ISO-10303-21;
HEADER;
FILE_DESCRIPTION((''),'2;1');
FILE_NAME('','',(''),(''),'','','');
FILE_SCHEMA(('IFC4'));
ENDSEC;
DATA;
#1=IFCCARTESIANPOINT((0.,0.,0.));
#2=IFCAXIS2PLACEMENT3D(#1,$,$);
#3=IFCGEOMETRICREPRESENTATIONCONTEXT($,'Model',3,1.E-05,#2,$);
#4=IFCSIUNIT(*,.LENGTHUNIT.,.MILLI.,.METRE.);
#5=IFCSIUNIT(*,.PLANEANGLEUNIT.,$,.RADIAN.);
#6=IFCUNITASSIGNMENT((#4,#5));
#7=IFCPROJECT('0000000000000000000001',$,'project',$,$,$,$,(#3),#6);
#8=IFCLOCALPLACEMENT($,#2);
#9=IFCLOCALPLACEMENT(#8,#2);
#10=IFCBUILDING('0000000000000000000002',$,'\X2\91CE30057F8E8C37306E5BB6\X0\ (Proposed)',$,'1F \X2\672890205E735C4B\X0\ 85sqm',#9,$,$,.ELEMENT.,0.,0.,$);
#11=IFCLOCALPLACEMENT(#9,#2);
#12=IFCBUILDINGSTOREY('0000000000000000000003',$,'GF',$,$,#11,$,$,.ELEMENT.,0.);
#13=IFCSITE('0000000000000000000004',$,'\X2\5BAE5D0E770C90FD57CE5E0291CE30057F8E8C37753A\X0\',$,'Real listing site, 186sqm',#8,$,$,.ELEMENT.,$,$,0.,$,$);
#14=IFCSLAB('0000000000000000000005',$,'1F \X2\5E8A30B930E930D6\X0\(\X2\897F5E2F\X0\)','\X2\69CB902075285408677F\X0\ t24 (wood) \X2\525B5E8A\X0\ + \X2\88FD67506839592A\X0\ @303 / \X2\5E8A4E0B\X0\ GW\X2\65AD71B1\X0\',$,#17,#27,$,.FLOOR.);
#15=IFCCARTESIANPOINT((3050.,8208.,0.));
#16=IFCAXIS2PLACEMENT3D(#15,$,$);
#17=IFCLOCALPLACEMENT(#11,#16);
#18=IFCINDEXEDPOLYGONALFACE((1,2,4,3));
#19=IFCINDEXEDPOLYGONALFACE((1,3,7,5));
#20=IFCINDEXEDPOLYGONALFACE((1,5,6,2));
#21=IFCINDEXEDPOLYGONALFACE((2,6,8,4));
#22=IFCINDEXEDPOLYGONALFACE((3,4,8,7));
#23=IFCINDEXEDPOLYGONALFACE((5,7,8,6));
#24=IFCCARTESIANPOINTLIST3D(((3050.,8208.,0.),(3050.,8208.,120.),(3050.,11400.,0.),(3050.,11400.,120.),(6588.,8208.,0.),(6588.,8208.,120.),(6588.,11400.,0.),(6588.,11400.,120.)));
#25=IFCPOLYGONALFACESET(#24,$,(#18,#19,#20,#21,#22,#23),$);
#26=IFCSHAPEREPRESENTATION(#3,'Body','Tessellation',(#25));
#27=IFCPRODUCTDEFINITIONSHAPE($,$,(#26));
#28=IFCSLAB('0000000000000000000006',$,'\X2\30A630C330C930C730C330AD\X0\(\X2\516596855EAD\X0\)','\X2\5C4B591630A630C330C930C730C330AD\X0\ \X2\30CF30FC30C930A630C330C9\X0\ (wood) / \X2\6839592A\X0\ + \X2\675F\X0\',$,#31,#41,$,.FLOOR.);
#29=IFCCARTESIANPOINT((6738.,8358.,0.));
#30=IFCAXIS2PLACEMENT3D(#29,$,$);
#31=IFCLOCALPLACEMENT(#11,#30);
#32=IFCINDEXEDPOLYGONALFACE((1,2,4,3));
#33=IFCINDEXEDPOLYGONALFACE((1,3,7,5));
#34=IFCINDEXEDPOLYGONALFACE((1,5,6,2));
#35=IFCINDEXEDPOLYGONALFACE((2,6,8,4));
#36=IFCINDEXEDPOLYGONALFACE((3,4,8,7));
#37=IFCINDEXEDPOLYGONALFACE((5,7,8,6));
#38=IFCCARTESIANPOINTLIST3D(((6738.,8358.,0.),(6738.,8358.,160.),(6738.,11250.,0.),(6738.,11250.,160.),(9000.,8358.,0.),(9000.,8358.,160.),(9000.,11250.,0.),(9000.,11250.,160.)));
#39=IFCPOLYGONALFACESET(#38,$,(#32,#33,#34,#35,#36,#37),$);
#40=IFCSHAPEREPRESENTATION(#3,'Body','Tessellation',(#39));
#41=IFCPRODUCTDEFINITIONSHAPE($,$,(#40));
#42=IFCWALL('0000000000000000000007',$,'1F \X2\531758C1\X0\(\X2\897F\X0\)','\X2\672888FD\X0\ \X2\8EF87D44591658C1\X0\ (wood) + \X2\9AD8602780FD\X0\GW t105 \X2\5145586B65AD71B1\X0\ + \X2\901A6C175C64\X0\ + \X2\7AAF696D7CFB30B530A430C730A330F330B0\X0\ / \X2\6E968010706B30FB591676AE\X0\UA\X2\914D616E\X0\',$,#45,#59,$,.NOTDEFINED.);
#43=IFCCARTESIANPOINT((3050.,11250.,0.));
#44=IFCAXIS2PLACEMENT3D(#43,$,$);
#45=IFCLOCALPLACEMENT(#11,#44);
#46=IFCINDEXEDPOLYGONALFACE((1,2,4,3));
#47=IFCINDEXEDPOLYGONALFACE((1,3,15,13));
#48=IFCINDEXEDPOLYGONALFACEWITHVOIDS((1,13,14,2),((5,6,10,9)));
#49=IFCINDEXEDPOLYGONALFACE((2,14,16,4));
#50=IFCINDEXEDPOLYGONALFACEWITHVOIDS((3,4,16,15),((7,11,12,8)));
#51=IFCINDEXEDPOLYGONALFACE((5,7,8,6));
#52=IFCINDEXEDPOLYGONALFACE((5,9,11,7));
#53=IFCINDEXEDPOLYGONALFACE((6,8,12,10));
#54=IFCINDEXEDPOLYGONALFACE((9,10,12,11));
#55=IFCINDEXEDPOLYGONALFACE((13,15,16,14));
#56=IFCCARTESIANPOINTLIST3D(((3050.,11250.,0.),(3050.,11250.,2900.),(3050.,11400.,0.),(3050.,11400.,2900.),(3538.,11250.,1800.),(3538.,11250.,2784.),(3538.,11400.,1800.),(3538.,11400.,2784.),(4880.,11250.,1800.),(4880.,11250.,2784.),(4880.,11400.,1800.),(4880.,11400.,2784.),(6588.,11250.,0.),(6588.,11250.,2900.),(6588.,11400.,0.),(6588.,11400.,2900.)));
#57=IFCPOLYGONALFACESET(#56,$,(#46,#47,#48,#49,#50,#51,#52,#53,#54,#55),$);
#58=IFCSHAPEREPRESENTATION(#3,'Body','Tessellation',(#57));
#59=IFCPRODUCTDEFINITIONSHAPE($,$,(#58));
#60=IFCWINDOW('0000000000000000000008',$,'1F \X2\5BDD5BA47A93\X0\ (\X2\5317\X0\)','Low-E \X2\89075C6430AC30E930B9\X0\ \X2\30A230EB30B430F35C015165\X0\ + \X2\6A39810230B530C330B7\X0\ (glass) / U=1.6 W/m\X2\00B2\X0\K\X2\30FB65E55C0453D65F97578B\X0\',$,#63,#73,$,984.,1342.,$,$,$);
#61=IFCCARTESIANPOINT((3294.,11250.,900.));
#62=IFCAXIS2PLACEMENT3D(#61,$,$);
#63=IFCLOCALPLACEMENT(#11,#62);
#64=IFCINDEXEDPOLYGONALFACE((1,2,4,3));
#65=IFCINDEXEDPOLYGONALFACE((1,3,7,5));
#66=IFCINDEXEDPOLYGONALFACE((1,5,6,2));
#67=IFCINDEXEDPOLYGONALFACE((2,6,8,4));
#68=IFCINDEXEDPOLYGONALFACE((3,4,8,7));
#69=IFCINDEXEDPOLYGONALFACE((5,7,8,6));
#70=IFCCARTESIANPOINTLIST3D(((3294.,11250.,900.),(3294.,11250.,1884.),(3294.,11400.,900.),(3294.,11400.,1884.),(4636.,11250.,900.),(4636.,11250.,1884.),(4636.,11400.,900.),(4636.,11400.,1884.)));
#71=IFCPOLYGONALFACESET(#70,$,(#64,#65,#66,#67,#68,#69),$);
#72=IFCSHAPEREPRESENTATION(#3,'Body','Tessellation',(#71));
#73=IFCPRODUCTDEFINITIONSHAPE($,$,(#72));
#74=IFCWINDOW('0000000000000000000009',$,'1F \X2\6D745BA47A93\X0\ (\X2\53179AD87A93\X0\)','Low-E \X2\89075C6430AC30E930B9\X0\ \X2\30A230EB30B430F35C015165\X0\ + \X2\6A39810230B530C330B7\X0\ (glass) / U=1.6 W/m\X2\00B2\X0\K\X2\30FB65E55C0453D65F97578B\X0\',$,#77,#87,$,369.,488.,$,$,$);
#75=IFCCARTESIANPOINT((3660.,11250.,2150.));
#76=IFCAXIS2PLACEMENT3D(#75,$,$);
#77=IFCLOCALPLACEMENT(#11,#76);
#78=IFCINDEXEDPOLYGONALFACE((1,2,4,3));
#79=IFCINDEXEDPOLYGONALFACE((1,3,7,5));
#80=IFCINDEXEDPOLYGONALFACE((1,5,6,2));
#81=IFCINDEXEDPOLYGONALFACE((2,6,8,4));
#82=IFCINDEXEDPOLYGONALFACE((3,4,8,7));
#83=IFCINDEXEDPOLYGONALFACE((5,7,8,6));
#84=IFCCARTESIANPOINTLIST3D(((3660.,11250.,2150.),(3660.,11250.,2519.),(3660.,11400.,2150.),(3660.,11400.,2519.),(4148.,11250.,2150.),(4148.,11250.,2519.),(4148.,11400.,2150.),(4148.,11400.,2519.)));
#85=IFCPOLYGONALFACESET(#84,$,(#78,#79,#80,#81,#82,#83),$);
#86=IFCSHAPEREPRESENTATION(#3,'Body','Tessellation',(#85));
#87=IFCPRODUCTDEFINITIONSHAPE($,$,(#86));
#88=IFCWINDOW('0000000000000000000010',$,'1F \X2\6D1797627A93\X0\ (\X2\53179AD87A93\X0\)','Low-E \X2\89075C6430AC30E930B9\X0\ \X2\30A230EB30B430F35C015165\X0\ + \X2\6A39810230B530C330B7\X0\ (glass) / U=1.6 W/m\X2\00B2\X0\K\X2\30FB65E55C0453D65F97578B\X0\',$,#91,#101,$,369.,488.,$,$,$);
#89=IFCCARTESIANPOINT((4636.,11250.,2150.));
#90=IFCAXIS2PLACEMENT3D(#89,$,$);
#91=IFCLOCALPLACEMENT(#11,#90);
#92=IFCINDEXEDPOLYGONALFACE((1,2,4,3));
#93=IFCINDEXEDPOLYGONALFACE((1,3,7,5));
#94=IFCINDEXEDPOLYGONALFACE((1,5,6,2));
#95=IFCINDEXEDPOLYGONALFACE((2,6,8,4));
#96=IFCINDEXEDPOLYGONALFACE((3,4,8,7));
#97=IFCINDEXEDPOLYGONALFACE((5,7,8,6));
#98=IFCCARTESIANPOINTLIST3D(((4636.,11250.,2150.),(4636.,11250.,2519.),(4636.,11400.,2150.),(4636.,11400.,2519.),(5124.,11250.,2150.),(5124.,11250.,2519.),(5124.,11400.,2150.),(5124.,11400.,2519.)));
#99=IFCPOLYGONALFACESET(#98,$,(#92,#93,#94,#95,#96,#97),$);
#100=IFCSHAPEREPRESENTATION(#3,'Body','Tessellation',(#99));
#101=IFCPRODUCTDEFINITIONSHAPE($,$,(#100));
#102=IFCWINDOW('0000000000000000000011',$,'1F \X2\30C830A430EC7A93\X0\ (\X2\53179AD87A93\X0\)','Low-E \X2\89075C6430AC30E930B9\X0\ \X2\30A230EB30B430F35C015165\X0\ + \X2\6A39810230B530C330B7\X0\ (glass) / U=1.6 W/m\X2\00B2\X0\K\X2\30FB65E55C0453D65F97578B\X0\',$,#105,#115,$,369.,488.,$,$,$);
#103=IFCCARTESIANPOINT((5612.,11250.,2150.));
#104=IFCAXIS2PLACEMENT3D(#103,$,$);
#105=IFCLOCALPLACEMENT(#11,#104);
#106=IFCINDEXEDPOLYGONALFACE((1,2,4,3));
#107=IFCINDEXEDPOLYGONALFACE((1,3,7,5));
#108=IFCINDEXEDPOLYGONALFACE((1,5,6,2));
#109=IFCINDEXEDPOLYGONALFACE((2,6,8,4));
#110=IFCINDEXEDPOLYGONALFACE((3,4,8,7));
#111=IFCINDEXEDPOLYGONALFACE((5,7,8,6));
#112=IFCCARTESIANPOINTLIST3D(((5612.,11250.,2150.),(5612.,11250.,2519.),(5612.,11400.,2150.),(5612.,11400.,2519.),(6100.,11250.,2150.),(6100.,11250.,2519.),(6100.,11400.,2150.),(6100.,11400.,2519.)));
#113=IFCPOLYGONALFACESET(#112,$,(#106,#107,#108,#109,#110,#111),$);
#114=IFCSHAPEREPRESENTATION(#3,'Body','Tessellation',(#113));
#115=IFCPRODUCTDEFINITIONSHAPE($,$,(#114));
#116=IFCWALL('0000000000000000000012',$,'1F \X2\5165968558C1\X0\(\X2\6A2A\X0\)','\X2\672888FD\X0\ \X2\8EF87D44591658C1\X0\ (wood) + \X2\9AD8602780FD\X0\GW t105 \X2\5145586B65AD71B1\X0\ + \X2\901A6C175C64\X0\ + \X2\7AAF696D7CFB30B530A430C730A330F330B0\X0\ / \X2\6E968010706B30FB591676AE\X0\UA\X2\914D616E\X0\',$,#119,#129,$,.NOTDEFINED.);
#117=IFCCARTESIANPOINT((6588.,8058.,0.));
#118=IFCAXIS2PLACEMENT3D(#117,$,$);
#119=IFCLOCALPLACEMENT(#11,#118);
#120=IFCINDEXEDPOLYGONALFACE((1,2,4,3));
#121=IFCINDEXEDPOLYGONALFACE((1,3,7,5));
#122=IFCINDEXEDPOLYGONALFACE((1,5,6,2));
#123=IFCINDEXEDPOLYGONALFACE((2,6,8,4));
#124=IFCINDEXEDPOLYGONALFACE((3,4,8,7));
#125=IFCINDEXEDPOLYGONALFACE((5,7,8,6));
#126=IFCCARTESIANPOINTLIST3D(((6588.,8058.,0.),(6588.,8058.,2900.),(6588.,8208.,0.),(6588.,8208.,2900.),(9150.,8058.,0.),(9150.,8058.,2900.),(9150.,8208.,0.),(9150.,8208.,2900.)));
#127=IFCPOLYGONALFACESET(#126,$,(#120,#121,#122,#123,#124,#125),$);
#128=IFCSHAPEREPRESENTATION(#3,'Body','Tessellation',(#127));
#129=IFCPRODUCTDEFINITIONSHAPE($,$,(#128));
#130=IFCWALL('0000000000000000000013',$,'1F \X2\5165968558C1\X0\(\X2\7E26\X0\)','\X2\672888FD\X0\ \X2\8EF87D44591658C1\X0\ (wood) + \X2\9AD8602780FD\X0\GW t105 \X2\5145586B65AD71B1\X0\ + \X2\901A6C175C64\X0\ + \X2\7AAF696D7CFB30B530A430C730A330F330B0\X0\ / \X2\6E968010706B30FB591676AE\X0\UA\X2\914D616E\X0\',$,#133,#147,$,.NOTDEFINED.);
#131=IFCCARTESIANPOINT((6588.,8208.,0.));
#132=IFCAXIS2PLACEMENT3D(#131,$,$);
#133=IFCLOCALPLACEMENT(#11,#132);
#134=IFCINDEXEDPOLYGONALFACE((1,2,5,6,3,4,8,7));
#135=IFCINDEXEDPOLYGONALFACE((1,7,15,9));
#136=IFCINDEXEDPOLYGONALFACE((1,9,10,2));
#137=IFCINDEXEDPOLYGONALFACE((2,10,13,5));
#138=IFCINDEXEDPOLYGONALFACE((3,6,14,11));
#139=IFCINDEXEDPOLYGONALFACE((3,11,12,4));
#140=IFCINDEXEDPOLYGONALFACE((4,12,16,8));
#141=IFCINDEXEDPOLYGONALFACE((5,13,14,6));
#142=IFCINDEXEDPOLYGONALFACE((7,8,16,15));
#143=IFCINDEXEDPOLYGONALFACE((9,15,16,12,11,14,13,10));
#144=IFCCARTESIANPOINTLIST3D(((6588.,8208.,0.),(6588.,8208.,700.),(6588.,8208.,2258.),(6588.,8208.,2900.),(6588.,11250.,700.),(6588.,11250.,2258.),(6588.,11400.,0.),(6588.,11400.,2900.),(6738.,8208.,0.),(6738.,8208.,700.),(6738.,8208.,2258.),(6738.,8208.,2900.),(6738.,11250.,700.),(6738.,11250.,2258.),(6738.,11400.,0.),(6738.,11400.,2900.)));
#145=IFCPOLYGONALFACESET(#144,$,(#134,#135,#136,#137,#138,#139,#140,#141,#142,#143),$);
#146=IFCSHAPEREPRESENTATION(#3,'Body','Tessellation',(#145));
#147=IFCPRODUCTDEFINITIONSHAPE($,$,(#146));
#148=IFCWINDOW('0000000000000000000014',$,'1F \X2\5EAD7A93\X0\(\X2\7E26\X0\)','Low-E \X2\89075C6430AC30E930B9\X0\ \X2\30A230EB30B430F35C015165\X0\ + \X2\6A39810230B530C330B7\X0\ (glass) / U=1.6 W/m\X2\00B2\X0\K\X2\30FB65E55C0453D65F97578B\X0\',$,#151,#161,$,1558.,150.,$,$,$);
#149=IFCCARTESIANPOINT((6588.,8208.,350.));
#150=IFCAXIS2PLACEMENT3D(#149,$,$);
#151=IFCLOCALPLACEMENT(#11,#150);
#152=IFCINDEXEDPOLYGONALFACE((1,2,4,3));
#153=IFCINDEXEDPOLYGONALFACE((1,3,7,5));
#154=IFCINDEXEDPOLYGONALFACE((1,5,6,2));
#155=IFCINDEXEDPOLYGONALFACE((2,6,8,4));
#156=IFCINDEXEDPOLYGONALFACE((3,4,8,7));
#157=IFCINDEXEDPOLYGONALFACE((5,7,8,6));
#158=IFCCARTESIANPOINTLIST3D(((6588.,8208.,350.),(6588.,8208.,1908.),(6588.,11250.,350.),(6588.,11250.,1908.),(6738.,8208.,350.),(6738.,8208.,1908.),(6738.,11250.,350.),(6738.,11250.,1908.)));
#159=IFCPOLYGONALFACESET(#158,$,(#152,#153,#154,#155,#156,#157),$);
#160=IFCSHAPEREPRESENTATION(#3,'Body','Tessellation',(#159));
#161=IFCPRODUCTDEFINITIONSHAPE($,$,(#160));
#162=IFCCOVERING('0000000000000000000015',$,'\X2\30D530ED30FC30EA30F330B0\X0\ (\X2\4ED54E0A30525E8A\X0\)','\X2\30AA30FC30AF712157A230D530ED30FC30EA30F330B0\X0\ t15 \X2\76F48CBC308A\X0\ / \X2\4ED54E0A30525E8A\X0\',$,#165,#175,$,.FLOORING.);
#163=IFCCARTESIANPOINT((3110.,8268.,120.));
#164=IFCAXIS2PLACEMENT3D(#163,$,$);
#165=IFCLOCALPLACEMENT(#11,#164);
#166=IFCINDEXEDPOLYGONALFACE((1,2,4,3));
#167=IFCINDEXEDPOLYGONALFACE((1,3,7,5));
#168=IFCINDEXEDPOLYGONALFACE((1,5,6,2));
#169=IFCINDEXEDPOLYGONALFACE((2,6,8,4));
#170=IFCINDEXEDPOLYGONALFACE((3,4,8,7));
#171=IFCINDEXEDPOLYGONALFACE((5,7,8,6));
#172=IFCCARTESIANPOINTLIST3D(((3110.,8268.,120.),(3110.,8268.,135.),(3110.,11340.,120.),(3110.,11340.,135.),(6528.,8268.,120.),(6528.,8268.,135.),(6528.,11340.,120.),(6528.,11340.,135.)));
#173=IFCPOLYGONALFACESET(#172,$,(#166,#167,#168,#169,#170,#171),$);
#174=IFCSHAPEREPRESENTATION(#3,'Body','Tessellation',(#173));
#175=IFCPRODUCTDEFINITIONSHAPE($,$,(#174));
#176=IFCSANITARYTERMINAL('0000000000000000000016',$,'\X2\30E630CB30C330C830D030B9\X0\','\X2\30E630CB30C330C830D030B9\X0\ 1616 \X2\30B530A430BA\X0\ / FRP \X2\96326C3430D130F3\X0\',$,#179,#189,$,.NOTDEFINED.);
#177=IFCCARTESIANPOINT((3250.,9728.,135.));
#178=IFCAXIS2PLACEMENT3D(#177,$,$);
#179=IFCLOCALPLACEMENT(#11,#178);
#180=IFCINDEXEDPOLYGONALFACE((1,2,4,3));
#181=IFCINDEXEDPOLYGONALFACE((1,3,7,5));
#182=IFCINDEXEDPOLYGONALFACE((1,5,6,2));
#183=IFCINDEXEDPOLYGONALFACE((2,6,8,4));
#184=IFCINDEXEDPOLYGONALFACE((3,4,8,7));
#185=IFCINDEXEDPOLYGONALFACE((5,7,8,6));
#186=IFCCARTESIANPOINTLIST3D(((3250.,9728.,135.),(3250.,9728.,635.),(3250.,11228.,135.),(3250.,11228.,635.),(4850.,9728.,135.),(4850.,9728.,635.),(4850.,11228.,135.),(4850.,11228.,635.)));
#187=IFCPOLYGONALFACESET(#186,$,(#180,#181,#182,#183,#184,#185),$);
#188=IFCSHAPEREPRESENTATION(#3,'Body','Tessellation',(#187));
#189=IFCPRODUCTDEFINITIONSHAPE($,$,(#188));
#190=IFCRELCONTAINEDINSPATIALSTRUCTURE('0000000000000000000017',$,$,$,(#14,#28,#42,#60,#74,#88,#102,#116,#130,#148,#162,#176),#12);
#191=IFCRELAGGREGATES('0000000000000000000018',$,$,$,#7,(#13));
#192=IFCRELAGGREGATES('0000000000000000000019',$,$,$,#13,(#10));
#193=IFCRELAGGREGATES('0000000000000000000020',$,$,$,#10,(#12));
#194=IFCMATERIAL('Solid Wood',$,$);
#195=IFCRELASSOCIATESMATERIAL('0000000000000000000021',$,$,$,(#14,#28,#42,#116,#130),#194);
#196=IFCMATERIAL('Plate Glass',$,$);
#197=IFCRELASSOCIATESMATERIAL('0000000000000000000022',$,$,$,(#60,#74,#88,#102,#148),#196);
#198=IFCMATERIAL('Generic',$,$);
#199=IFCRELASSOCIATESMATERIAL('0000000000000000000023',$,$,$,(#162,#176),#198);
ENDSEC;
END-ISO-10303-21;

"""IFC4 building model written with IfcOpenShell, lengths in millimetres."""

from ifc_helpers import new_model, si_unit, frame, frame_2d, origin, place, context, project, spatial, rectangle, extrude, material, element, fill, save


model = new_model("IFC4")

# Units and contexts
model_context = context("Model", 3, precision=1e-05, world=origin())
ifc_project = project(units=[si_unit("LENGTHUNIT", "METRE", prefix="MILLI"), si_unit("PLANEANGLEUNIT", "RADIAN")], contexts=[model_context])

# Site, building, storey
site_placement = place(None, origin())
site = spatial("IfcSite", under=ifc_project, at=site_placement, Name="宮崎県都城市野々美谷町", ObjectType="Real listing site, 186sqm", CompositionType="ELEMENT", RefElevation=0.0)
building_placement = place(site_placement, origin())
building = spatial("IfcBuilding", under=site, at=building_placement, Name="野々美谷の家 (Proposed)", ObjectType="1F 木造平屋 85sqm", CompositionType="ELEMENT", ElevationOfRefHeight=0.0, ElevationOfTerrain=0.0)
storey_placement = place(building_placement, origin())
storey = spatial("IfcBuildingStorey", under=building, at=storey_placement, Name="GF", CompositionType="ELEMENT", Elevation=0.0)

# Slabs
ifc_material_1 = material(Name="Solid Wood")
slab_1_placement = place(storey_placement, frame((3050.0, 8208.0, 0.0)))
element("IfcSlab", 1, at=slab_1_placement, inside=storey, material=ifc_material_1, Name="1F 床スラブ(西帯)", Description="構造用合板 t24 (wood) 剛床 + 製材根太 @303 / 床下 GW断熱", PredefinedType="FLOOR", context=model_context, shape_type="SweptSolid", body=[
    extrude(rectangle(XDim=3538.0, YDim=3192.0, at=frame_2d((1769.0, 1596.0))), frame((3050.0, 8208.0, 0.0)), (0.0, 0.0, 1.0), 120.0),
])
slab_2_placement = place(storey_placement, frame((6738.0, 8358.0, 0.0)))
element("IfcSlab", 2, at=slab_2_placement, inside=storey, material=ifc_material_1, Name="ウッドデッキ(入隅庭)", Description="屋外ウッドデッキ ハードウッド (wood) / 根太 + 束", PredefinedType="FLOOR", context=model_context, shape_type="SweptSolid", body=[
    extrude(rectangle(XDim=2262.0, YDim=2892.0, at=frame_2d((1131.0, 1446.0))), frame((6738.0, 8358.0, 0.0)), (0.0, 0.0, 1.0), 160.0),
])

# Wall, openings, windows
wall_1_placement = place(storey_placement, frame((3050.0, 11250.0, 0.0)))
wall_1 = element("IfcWall", 3, at=wall_1_placement, inside=storey, material=ifc_material_1, Name="1F 北壁(西)", Description="木製 軸組外壁 (wood) + 高性能GW t105 充填断熱 + 通気層 + 窯業系サイディング / 準耐火・外皮UA配慮", PredefinedType="NOTDEFINED", context=model_context, shape_type="SweptSolid", body=[
    extrude(rectangle(XDim=3538.0, YDim=150.0, at=frame_2d((1769.0, 75.0))), frame((3050.0, 11250.0, 0.0)), (0.0, 0.0, 1.0), 2900.0),
])
opening_1_placement = place(storey_placement, frame((3294.0, 11250.0, 900.0)))
opening_1 = element("IfcOpeningElement", 4, at=opening_1_placement, cuts=wall_1, PredefinedType="NOTDEFINED", context=model_context, shape_type="SweptSolid", body=[
    extrude(rectangle(XDim=1342.0, YDim=150.0, at=frame_2d((671.0, 75.0))), frame((3294.0, 11250.0, 900.0)), (0.0, 0.0, 1.0), 984.0),
])
opening_2_placement = place(storey_placement, frame((3660.0, 11250.0, 2150.0)))
opening_2 = element("IfcOpeningElement", 5, at=opening_2_placement, cuts=wall_1, PredefinedType="NOTDEFINED", context=model_context, shape_type="SweptSolid", body=[
    extrude(rectangle(XDim=488.0, YDim=150.0, at=frame_2d((244.0, 75.0))), frame((3660.0, 11250.0, 2150.0)), (0.0, 0.0, 1.0), 369.0),
])
opening_3_placement = place(storey_placement, frame((4636.0, 11250.0, 2150.0)))
opening_3 = element("IfcOpeningElement", 6, at=opening_3_placement, cuts=wall_1, PredefinedType="NOTDEFINED", context=model_context, shape_type="SweptSolid", body=[
    extrude(rectangle(XDim=488.0, YDim=150.0, at=frame_2d((244.0, 75.0))), frame((4636.0, 11250.0, 2150.0)), (0.0, 0.0, 1.0), 369.0),
])
opening_4_placement = place(storey_placement, frame((5612.0, 11250.0, 2150.0)))
opening_4 = element("IfcOpeningElement", 7, at=opening_4_placement, cuts=wall_1, PredefinedType="NOTDEFINED", context=model_context, shape_type="SweptSolid", body=[
    extrude(rectangle(XDim=488.0, YDim=150.0, at=frame_2d((244.0, 75.0))), frame((5612.0, 11250.0, 2150.0)), (0.0, 0.0, 1.0), 369.0),
])
ifc_material_2 = material(Name="Plate Glass")
window_1_placement = place(storey_placement, frame((3294.0, 11250.0, 900.0)))
window_1 = element("IfcWindow", 8, at=window_1_placement, inside=storey, material=ifc_material_2, Name="1F 寝室窓 (北)", Description="Low-E 複層ガラス アルゴン封入 + 樹脂サッシ (glass) / U=1.6 W/m²K・日射取得型", OverallHeight=984.0, OverallWidth=1342.0, context=model_context, shape_type="SweptSolid", body=[
    extrude(rectangle(XDim=1342.0, YDim=150.0, at=frame_2d((671.0, 75.0))), frame((3294.0, 11250.0, 900.0)), (0.0, 0.0, 1.0), 984.0),
])
fill(opening_1, window_1)
window_2_placement = place(storey_placement, frame((3660.0, 11250.0, 2150.0)))
window_2 = element("IfcWindow", 9, at=window_2_placement, inside=storey, material=ifc_material_2, Name="1F 浴室窓 (北高窓)", Description="Low-E 複層ガラス アルゴン封入 + 樹脂サッシ (glass) / U=1.6 W/m²K・日射取得型", OverallHeight=369.0, OverallWidth=488.0, context=model_context, shape_type="SweptSolid", body=[
    extrude(rectangle(XDim=488.0, YDim=150.0, at=frame_2d((244.0, 75.0))), frame((3660.0, 11250.0, 2150.0)), (0.0, 0.0, 1.0), 369.0),
])
fill(opening_2, window_2)
window_3_placement = place(storey_placement, frame((4636.0, 11250.0, 2150.0)))
window_3 = element("IfcWindow", 10, at=window_3_placement, inside=storey, material=ifc_material_2, Name="1F 洗面窓 (北高窓)", Description="Low-E 複層ガラス アルゴン封入 + 樹脂サッシ (glass) / U=1.6 W/m²K・日射取得型", OverallHeight=369.0, OverallWidth=488.0, context=model_context, shape_type="SweptSolid", body=[
    extrude(rectangle(XDim=488.0, YDim=150.0, at=frame_2d((244.0, 75.0))), frame((4636.0, 11250.0, 2150.0)), (0.0, 0.0, 1.0), 369.0),
])
fill(opening_3, window_3)
window_4_placement = place(storey_placement, frame((5612.0, 11250.0, 2150.0)))
window_4 = element("IfcWindow", 11, at=window_4_placement, inside=storey, material=ifc_material_2, Name="1F トイレ窓 (北高窓)", Description="Low-E 複層ガラス アルゴン封入 + 樹脂サッシ (glass) / U=1.6 W/m²K・日射取得型", OverallHeight=369.0, OverallWidth=488.0, context=model_context, shape_type="SweptSolid", body=[
    extrude(rectangle(XDim=488.0, YDim=150.0, at=frame_2d((244.0, 75.0))), frame((5612.0, 11250.0, 2150.0)), (0.0, 0.0, 1.0), 369.0),
])
fill(opening_4, window_4)

# Wall
wall_2_placement = place(storey_placement, frame((6588.0, 8058.0, 0.0)))
element("IfcWall", 12, at=wall_2_placement, inside=storey, material=ifc_material_1, Name="1F 入隅壁(横)", Description="木製 軸組外壁 (wood) + 高性能GW t105 充填断熱 + 通気層 + 窯業系サイディング / 準耐火・外皮UA配慮", PredefinedType="NOTDEFINED", context=model_context, shape_type="SweptSolid", body=[
    extrude(rectangle(XDim=2562.0, YDim=150.0, at=frame_2d((1281.0, 75.0))), frame((6588.0, 8058.0, 0.0)), (0.0, 0.0, 1.0), 2900.0),
])

# Wall, opening, window
wall_3_placement = place(storey_placement, frame((6588.0, 8208.0, 0.0)))
wall_3 = element("IfcWall", 13, at=wall_3_placement, inside=storey, material=ifc_material_1, Name="1F 入隅壁(縦)", Description="木製 軸組外壁 (wood) + 高性能GW t105 充填断熱 + 通気層 + 窯業系サイディング / 準耐火・外皮UA配慮", PredefinedType="NOTDEFINED", context=model_context, shape_type="SweptSolid", body=[
    extrude(rectangle(XDim=150.0, YDim=3192.0, at=frame_2d((75.0, 1596.0))), frame((6588.0, 8208.0, 0.0)), (0.0, 0.0, 1.0), 2900.0),
])
opening_5_placement = place(storey_placement, frame((6588.0, 8208.0, 350.0)))
opening_5 = element("IfcOpeningElement", 14, at=opening_5_placement, cuts=wall_3, PredefinedType="NOTDEFINED", context=model_context, shape_type="SweptSolid", body=[
    extrude(rectangle(XDim=150.0, YDim=3042.0, at=frame_2d((75.0, 1521.0))), frame((6588.0, 8208.0, 350.0)), (0.0, 0.0, 1.0), 1558.0),
])
window_5_placement = place(storey_placement, frame((6588.0, 8208.0, 350.0)))
window_5 = element("IfcWindow", 15, at=window_5_placement, inside=storey, material=ifc_material_2, Name="1F 庭窓(縦)", Description="Low-E 複層ガラス アルゴン封入 + 樹脂サッシ (glass) / U=1.6 W/m²K・日射取得型", OverallHeight=1558.0, OverallWidth=150.0, context=model_context, shape_type="SweptSolid", body=[
    extrude(rectangle(XDim=150.0, YDim=3042.0, at=frame_2d((75.0, 1521.0))), frame((6588.0, 8208.0, 350.0)), (0.0, 0.0, 1.0), 1558.0),
])
fill(opening_5, window_5)

# Covering
ifc_material_3 = material(Name="Generic")
covering_placement = place(storey_placement, frame((3110.0, 8268.0, 120.0)))
element("IfcCovering", 16, at=covering_placement, inside=storey, material=ifc_material_3, Name="フローリング (仕上げ床)", Description="オーク無垢フローリング t15 直貼り / 仕上げ床", PredefinedType="FLOORING", context=model_context, shape_type="SweptSolid", body=[
    extrude(rectangle(XDim=3418.0, YDim=3072.0, at=frame_2d((1709.0, 1536.0))), frame((3110.0, 8268.0, 120.0)), (0.0, 0.0, 1.0), 15.0),
])

# Sanitary terminal
sanitary_terminal_1_placement = place(storey_placement, frame((3250.0, 9728.0, 135.0)))
element("IfcSanitaryTerminal", 17, at=sanitary_terminal_1_placement, inside=storey, material=ifc_material_3, Name="ユニットバス", Description="ユニットバス 1616 サイズ / FRP 防水パン", PredefinedType="NOTDEFINED", context=model_context, shape_type="SweptSolid", body=[
    extrude(rectangle(XDim=1600.0, YDim=1500.0, at=frame_2d((800.0, 750.0))), frame((3250.0, 9728.0, 135.0)), (0.0, 0.0, 1.0), 500.0),
])

save(model, "model.ifc")
